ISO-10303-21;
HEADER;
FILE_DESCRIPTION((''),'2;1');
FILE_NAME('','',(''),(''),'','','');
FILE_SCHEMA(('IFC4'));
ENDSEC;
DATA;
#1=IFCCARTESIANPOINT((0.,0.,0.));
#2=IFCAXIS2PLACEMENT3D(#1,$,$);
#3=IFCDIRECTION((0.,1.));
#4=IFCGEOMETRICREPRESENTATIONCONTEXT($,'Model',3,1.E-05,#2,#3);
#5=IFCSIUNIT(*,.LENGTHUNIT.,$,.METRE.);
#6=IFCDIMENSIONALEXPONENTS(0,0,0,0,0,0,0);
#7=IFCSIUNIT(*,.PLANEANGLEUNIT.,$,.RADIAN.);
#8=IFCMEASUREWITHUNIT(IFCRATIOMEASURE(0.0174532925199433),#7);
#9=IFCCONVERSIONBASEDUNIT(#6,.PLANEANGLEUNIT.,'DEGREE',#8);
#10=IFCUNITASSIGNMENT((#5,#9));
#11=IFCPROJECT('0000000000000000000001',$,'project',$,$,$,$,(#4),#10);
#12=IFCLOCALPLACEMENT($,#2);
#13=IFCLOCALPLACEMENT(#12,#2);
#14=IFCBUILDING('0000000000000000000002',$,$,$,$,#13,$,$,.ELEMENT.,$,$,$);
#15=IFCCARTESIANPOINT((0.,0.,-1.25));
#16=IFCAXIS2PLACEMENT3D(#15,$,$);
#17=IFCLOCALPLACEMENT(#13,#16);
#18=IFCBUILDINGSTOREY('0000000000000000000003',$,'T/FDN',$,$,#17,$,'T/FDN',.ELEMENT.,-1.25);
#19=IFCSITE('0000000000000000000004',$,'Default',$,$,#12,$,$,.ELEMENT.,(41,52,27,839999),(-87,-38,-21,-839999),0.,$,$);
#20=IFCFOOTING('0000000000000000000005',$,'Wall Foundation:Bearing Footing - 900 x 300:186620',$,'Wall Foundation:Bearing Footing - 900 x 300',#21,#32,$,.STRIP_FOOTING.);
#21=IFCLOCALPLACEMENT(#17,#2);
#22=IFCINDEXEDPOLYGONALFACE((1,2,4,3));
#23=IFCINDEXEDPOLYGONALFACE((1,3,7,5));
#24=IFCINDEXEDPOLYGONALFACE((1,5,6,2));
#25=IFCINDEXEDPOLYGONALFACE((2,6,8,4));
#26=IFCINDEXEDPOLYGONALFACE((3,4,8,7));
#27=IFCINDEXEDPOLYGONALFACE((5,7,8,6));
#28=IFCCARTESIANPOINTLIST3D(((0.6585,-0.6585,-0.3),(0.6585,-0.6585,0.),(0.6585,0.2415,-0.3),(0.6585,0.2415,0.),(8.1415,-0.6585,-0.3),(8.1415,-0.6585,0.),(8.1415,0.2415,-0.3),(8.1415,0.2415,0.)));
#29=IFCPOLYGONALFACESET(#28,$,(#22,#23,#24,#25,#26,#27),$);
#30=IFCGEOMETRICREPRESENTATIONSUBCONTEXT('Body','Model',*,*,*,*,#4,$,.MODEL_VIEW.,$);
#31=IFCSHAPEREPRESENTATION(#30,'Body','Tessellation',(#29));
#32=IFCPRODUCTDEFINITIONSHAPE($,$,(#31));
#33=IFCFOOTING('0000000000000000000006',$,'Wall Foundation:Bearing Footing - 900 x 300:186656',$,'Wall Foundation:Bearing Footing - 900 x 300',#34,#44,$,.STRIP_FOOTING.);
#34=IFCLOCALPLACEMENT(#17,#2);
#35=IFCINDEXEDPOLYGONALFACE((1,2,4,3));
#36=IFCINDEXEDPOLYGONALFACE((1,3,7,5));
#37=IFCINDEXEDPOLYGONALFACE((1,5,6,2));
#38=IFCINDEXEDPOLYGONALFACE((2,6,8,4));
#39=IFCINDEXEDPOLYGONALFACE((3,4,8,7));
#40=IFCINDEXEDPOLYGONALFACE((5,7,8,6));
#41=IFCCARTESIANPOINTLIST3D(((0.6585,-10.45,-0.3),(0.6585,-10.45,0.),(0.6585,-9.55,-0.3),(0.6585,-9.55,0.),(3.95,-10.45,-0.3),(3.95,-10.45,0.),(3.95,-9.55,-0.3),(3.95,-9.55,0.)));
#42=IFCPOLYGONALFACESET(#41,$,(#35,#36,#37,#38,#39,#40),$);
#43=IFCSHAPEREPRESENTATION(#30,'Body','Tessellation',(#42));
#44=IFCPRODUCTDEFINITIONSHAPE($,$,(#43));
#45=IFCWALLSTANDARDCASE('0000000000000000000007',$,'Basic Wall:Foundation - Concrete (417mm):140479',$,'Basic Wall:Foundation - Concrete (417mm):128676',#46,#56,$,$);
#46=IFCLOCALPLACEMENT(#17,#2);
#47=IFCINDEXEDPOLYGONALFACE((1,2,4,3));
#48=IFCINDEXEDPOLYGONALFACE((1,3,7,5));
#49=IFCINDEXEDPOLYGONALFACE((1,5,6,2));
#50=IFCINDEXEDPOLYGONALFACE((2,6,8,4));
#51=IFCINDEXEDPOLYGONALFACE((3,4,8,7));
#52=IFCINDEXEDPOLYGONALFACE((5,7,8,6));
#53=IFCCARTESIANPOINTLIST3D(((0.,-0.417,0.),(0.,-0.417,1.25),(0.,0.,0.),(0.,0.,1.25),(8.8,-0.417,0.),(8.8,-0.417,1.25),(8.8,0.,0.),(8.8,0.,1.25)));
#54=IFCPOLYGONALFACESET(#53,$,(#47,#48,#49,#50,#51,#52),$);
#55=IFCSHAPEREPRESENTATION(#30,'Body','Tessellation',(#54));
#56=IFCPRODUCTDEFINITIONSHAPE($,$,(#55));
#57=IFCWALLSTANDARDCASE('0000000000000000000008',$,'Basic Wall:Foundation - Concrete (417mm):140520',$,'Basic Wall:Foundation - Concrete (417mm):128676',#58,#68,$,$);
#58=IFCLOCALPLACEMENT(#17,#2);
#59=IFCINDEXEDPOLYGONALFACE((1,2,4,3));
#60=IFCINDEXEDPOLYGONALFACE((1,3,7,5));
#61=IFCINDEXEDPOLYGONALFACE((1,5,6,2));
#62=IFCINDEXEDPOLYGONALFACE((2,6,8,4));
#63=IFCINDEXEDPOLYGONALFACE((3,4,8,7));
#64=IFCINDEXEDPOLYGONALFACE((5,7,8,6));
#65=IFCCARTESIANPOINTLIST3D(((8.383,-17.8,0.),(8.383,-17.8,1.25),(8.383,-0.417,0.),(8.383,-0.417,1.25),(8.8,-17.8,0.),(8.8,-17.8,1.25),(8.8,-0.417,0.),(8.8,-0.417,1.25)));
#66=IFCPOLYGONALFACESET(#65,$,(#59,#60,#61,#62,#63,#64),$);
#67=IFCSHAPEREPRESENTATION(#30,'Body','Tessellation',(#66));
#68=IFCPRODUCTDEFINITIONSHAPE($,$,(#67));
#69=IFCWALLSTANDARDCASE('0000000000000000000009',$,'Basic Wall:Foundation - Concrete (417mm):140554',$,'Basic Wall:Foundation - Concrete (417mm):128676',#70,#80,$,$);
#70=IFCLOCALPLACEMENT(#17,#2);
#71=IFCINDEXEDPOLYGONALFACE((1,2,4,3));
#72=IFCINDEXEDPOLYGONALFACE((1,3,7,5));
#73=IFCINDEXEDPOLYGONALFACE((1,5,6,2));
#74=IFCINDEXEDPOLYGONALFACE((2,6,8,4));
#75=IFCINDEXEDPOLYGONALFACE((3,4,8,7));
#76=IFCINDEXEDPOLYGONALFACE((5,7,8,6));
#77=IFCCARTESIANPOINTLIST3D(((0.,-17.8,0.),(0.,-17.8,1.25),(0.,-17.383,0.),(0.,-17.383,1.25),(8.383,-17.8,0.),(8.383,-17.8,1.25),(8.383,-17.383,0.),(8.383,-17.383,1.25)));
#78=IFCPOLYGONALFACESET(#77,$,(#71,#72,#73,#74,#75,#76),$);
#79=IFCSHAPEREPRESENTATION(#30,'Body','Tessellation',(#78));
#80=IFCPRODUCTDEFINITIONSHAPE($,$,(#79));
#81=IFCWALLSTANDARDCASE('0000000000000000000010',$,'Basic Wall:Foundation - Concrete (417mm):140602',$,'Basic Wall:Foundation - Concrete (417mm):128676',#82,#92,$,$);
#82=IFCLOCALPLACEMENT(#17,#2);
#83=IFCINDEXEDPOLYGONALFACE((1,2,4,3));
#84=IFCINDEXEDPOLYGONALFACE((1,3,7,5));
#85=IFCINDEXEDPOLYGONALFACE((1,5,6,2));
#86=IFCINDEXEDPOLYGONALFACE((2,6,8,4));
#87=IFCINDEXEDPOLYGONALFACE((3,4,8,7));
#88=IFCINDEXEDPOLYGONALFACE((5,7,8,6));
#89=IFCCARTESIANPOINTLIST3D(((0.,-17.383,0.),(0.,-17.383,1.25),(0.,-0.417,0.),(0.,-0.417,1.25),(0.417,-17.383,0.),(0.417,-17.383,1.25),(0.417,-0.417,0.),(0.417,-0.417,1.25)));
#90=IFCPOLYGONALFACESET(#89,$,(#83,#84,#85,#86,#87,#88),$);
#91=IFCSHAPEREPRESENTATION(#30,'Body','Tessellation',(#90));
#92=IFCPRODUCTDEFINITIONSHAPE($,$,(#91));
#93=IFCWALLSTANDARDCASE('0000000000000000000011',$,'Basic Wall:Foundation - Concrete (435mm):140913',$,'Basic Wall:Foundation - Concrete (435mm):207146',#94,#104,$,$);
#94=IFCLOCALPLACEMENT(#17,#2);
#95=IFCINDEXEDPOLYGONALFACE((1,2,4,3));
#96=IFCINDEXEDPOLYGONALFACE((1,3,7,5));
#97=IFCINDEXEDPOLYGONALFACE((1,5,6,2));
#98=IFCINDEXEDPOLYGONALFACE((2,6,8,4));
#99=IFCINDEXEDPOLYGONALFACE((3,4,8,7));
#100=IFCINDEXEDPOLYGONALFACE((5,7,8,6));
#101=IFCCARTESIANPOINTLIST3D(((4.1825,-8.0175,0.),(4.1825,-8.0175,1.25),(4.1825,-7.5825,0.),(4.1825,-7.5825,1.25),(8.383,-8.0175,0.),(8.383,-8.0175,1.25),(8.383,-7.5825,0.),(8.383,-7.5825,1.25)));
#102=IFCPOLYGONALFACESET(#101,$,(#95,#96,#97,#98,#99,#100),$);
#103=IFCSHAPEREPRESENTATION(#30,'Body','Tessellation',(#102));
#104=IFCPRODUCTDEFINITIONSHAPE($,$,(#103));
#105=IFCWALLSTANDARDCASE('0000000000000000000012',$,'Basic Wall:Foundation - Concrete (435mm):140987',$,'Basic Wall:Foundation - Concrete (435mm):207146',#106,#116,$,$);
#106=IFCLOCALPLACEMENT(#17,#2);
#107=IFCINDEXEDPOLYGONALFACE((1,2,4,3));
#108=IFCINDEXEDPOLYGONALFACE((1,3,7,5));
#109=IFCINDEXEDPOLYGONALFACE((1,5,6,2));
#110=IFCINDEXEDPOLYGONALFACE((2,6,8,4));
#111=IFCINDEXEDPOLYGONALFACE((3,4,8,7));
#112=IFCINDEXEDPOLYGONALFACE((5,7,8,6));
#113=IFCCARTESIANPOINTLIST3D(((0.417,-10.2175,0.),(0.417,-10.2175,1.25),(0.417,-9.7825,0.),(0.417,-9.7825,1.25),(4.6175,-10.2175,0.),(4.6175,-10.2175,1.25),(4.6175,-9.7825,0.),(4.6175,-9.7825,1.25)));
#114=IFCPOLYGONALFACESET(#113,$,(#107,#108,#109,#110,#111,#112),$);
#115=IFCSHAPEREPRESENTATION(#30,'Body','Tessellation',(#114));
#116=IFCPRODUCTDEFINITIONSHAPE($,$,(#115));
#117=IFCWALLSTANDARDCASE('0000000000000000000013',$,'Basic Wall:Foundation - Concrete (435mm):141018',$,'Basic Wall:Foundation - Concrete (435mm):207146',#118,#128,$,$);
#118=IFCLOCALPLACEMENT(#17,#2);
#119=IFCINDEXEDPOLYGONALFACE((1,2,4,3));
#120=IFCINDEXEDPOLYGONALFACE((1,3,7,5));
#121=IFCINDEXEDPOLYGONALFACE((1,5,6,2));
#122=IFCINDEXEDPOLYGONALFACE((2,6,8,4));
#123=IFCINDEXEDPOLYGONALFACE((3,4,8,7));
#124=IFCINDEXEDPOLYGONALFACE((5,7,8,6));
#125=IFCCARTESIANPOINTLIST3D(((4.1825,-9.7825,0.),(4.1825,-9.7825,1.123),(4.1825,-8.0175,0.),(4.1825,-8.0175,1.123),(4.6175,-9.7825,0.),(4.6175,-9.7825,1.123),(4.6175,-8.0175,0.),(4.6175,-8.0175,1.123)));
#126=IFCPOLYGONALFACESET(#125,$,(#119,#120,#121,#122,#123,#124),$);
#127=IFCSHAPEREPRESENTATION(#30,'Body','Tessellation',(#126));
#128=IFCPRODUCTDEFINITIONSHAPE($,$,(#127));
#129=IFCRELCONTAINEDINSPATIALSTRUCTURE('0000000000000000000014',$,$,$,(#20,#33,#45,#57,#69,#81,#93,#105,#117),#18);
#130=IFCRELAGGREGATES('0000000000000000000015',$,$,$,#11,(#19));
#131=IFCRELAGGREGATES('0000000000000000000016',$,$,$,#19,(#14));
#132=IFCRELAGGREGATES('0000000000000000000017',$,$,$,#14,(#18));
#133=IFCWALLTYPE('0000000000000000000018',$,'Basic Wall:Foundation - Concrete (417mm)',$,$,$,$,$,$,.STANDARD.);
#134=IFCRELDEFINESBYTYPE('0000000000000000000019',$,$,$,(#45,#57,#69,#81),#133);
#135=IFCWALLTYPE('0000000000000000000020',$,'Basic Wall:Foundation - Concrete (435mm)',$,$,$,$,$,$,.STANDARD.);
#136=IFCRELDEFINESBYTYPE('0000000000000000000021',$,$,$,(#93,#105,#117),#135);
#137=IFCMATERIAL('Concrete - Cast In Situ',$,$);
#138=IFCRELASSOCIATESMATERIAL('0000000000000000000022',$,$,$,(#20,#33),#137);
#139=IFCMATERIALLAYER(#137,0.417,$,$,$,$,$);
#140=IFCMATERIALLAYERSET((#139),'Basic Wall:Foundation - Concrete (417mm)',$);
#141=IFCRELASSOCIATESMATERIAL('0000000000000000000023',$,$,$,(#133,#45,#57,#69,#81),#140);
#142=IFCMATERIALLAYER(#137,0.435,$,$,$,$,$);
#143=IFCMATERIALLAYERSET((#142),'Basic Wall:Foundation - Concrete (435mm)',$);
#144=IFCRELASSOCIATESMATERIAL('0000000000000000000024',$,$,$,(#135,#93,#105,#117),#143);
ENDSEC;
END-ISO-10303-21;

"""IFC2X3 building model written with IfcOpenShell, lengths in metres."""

from ifc_helpers import new_model, entity, si_unit, converted_unit, direction, frame, frame_2d, origin, place, context, subcontext, project, spatial, rectangle, extrude, material, layer, layer_set, layer_usage, type_object, element, save


model = new_model("IFC2X3")

# Units and contexts
model_context = context("Model", 3, precision=1e-05, world=origin(), true_north=direction((0.0, 1.0)))
body_context = subcontext(model_context, "Body", "Model", "MODEL_VIEW")
ifc_project = project(units=[si_unit("LENGTHUNIT", "METRE"), converted_unit("PLANEANGLEUNIT", "DEGREE", entity("IfcRatioMeasure", 0.0174532925199433), si_unit("PLANEANGLEUNIT", "RADIAN"), dimensions=[0, 0, 0, 0, 0, 0, 0])], contexts=[model_context])

# Site, building, storey
site_placement = place(None, origin())
site = spatial("IfcSite", under=ifc_project, at=site_placement, Name="Default", CompositionType="ELEMENT", RefLatitude=(41, 52, 27, 839999), RefLongitude=(-87, -38, -21, -839999), RefElevation=0.0)
building_placement = place(site_placement, origin())
building = spatial("IfcBuilding", under=site, at=building_placement, CompositionType="ELEMENT")
storey_placement = place(building_placement, frame((0.0, 0.0, -1.25)))
storey = spatial("IfcBuildingStorey", under=building, at=storey_placement, Name="T/FDN", LongName="T/FDN", CompositionType="ELEMENT", Elevation=-1.25)

# Footings
ifc_material = material(Name="Concrete - Cast In Situ")
footing_1_placement = place(storey_placement, origin())
element("IfcFooting", 1, at=footing_1_placement, inside=storey, material=ifc_material, Name="Wall Foundation:Bearing Footing - 900 x 300:186620", ObjectType="Wall Foundation:Bearing Footing - 900 x 300", PredefinedType="STRIP_FOOTING", context=body_context, shape_type="SweptSolid", body=[
    extrude(rectangle(XDim=7.483, YDim=0.9, at=frame_2d((0.0, 0.0), x_axis=(1.0, 0.0))), frame((4.4, -0.2085, -0.3), z_axis=(0.0, 0.0, 1.0), x_axis=(-1.0, 0.0, 0.0)), (0.0, 0.0, 1.0), 0.3),
])
footing_2_placement = place(storey_placement, origin())
element("IfcFooting", 2, at=footing_2_placement, inside=storey, material=ifc_material, Name="Wall Foundation:Bearing Footing - 900 x 300:186656", ObjectType="Wall Foundation:Bearing Footing - 900 x 300", PredefinedType="STRIP_FOOTING", context=body_context, shape_type="SweptSolid", body=[
    extrude(rectangle(XDim=3.2915, YDim=0.9, at=frame_2d((0.0, 0.0), x_axis=(1.0, 0.0))), frame((2.3043, -10.0, -0.3)), (0.0, 0.0, 1.0), 0.3),
])

# Walls
ifc_layer_1 = layer(ifc_material, 0.417)
ifc_layer_set_1 = layer_set([ifc_layer_1], Name="Basic Wall:Foundation - Concrete (417mm)")
ifc_layer_usage_1 = layer_usage(ifc_layer_set_1, "AXIS2", "NEGATIVE", 0.2085)
wall_type_1 = type_object("IfcWallType", Name="Basic Wall:Foundation - Concrete (417mm)", PredefinedType="STANDARD", material=ifc_layer_set_1)
wall_1_placement = place(storey_placement, frame((0.0, -0.2085, 0.0)))
element("IfcWallStandardCase", 3, at=wall_1_placement, inside=storey, type_object=wall_type_1, material=ifc_layer_usage_1, Name="Basic Wall:Foundation - Concrete (417mm):140479", ObjectType="Basic Wall:Foundation - Concrete (417mm):128676", context=body_context, shape_type="SweptSolid", body=[
    extrude(rectangle(XDim=8.8, YDim=0.417, at=frame_2d((4.4, 0.0), x_axis=(-1.0, 0.0))), origin(), (0.0, 0.0, 1.0), 1.25),
])
ifc_layer_usage_2 = layer_usage(ifc_layer_set_1, "AXIS2", "NEGATIVE", 0.2085)
wall_2_placement = place(storey_placement, frame((8.5915, -0.417, 0.0), z_axis=(0.0, 0.0, 1.0), x_axis=(0.0, -1.0, 0.0)))
element("IfcWallStandardCase", 4, at=wall_2_placement, inside=storey, type_object=wall_type_1, material=ifc_layer_usage_2, Name="Basic Wall:Foundation - Concrete (417mm):140520", ObjectType="Basic Wall:Foundation - Concrete (417mm):128676", context=body_context, shape_type="SweptSolid", body=[
    extrude(rectangle(XDim=17.383, YDim=0.417, at=frame_2d((8.6915, 0.0), x_axis=(-1.0, 0.0))), origin(), (0.0, 0.0, 1.0), 1.25),
])
ifc_layer_usage_3 = layer_usage(ifc_layer_set_1, "AXIS2", "NEGATIVE", 0.2085)
wall_3_placement = place(storey_placement, frame((8.383, -17.5915, 0.0), z_axis=(0.0, 0.0, 1.0), x_axis=(-1.0, 0.0, 0.0)))
element("IfcWallStandardCase", 5, at=wall_3_placement, inside=storey, type_object=wall_type_1, material=ifc_layer_usage_3, Name="Basic Wall:Foundation - Concrete (417mm):140554", ObjectType="Basic Wall:Foundation - Concrete (417mm):128676", context=body_context, shape_type="SweptSolid", body=[
    extrude(rectangle(XDim=8.383, YDim=0.417, at=frame_2d((4.1915, 0.0), x_axis=(-1.0, 0.0))), origin(), (0.0, 0.0, 1.0), 1.25),
])
ifc_layer_usage_4 = layer_usage(ifc_layer_set_1, "AXIS2", "NEGATIVE", 0.2085)
wall_4_placement = place(storey_placement, frame((0.2085, -17.383, 0.0), z_axis=(0.0, 0.0, 1.0), x_axis=(0.0, 1.0, 0.0)))
element("IfcWallStandardCase", 6, at=wall_4_placement, inside=storey, type_object=wall_type_1, material=ifc_layer_usage_4, Name="Basic Wall:Foundation - Concrete (417mm):140602", ObjectType="Basic Wall:Foundation - Concrete (417mm):128676", context=body_context, shape_type="SweptSolid", body=[
    extrude(rectangle(XDim=16.966, YDim=0.417, at=frame_2d((8.483, 0.0), x_axis=(-1.0, 0.0))), origin(), (0.0, 0.0, 1.0), 1.25),
])
ifc_layer_2 = layer(ifc_material, 0.435)
ifc_layer_set_2 = layer_set([ifc_layer_2], Name="Basic Wall:Foundation - Concrete (435mm)")
ifc_layer_usage_5 = layer_usage(ifc_layer_set_2, "AXIS2", "NEGATIVE", 0.2175)
wall_type_2 = type_object("IfcWallType", Name="Basic Wall:Foundation - Concrete (435mm)", PredefinedType="STANDARD", material=ifc_layer_set_2)
wall_5_placement = place(storey_placement, frame((8.383, -7.8, 0.0), z_axis=(0.0, 0.0, 1.0), x_axis=(-1.0, 0.0, 0.0)))
element("IfcWallStandardCase", 7, at=wall_5_placement, inside=storey, type_object=wall_type_2, material=ifc_layer_usage_5, Name="Basic Wall:Foundation - Concrete (435mm):140913", ObjectType="Basic Wall:Foundation - Concrete (435mm):207146", context=body_context, shape_type="SweptSolid", body=[
    extrude(rectangle(XDim=4.2005, YDim=0.435, at=frame_2d((2.1002, 0.0), x_axis=(-1.0, 0.0))), origin(), (0.0, 0.0, 1.0), 1.25),
])
ifc_layer_usage_6 = layer_usage(ifc_layer_set_2, "AXIS2", "NEGATIVE", 0.2175)
wall_6_placement = place(storey_placement, frame((0.417, -10.0, 0.0)))
element("IfcWallStandardCase", 8, at=wall_6_placement, inside=storey, type_object=wall_type_2, material=ifc_layer_usage_6, Name="Basic Wall:Foundation - Concrete (435mm):140987", ObjectType="Basic Wall:Foundation - Concrete (435mm):207146", context=body_context, shape_type="SweptSolid", body=[
    extrude(rectangle(XDim=4.2005, YDim=0.435, at=frame_2d((2.1002, 0.0), x_axis=(-1.0, 0.0))), origin(), (0.0, 0.0, 1.0), 1.25),
])
ifc_layer_usage_7 = layer_usage(ifc_layer_set_2, "AXIS2", "NEGATIVE", 0.2175)
wall_7_placement = place(storey_placement, frame((4.4, -9.7825, 0.0), z_axis=(0.0, 0.0, 1.0), x_axis=(0.0, 1.0, 0.0)))
element("IfcWallStandardCase", 9, at=wall_7_placement, inside=storey, type_object=wall_type_2, material=ifc_layer_usage_7, Name="Basic Wall:Foundation - Concrete (435mm):141018", ObjectType="Basic Wall:Foundation - Concrete (435mm):207146", context=body_context, shape_type="SweptSolid", body=[
    extrude(rectangle(XDim=1.765, YDim=0.435, at=frame_2d((0.8825, 0.0), x_axis=(-1.0, 0.0))), origin(), (0.0, 0.0, 1.0), 1.123),
])

save(model, "model.ifc")
